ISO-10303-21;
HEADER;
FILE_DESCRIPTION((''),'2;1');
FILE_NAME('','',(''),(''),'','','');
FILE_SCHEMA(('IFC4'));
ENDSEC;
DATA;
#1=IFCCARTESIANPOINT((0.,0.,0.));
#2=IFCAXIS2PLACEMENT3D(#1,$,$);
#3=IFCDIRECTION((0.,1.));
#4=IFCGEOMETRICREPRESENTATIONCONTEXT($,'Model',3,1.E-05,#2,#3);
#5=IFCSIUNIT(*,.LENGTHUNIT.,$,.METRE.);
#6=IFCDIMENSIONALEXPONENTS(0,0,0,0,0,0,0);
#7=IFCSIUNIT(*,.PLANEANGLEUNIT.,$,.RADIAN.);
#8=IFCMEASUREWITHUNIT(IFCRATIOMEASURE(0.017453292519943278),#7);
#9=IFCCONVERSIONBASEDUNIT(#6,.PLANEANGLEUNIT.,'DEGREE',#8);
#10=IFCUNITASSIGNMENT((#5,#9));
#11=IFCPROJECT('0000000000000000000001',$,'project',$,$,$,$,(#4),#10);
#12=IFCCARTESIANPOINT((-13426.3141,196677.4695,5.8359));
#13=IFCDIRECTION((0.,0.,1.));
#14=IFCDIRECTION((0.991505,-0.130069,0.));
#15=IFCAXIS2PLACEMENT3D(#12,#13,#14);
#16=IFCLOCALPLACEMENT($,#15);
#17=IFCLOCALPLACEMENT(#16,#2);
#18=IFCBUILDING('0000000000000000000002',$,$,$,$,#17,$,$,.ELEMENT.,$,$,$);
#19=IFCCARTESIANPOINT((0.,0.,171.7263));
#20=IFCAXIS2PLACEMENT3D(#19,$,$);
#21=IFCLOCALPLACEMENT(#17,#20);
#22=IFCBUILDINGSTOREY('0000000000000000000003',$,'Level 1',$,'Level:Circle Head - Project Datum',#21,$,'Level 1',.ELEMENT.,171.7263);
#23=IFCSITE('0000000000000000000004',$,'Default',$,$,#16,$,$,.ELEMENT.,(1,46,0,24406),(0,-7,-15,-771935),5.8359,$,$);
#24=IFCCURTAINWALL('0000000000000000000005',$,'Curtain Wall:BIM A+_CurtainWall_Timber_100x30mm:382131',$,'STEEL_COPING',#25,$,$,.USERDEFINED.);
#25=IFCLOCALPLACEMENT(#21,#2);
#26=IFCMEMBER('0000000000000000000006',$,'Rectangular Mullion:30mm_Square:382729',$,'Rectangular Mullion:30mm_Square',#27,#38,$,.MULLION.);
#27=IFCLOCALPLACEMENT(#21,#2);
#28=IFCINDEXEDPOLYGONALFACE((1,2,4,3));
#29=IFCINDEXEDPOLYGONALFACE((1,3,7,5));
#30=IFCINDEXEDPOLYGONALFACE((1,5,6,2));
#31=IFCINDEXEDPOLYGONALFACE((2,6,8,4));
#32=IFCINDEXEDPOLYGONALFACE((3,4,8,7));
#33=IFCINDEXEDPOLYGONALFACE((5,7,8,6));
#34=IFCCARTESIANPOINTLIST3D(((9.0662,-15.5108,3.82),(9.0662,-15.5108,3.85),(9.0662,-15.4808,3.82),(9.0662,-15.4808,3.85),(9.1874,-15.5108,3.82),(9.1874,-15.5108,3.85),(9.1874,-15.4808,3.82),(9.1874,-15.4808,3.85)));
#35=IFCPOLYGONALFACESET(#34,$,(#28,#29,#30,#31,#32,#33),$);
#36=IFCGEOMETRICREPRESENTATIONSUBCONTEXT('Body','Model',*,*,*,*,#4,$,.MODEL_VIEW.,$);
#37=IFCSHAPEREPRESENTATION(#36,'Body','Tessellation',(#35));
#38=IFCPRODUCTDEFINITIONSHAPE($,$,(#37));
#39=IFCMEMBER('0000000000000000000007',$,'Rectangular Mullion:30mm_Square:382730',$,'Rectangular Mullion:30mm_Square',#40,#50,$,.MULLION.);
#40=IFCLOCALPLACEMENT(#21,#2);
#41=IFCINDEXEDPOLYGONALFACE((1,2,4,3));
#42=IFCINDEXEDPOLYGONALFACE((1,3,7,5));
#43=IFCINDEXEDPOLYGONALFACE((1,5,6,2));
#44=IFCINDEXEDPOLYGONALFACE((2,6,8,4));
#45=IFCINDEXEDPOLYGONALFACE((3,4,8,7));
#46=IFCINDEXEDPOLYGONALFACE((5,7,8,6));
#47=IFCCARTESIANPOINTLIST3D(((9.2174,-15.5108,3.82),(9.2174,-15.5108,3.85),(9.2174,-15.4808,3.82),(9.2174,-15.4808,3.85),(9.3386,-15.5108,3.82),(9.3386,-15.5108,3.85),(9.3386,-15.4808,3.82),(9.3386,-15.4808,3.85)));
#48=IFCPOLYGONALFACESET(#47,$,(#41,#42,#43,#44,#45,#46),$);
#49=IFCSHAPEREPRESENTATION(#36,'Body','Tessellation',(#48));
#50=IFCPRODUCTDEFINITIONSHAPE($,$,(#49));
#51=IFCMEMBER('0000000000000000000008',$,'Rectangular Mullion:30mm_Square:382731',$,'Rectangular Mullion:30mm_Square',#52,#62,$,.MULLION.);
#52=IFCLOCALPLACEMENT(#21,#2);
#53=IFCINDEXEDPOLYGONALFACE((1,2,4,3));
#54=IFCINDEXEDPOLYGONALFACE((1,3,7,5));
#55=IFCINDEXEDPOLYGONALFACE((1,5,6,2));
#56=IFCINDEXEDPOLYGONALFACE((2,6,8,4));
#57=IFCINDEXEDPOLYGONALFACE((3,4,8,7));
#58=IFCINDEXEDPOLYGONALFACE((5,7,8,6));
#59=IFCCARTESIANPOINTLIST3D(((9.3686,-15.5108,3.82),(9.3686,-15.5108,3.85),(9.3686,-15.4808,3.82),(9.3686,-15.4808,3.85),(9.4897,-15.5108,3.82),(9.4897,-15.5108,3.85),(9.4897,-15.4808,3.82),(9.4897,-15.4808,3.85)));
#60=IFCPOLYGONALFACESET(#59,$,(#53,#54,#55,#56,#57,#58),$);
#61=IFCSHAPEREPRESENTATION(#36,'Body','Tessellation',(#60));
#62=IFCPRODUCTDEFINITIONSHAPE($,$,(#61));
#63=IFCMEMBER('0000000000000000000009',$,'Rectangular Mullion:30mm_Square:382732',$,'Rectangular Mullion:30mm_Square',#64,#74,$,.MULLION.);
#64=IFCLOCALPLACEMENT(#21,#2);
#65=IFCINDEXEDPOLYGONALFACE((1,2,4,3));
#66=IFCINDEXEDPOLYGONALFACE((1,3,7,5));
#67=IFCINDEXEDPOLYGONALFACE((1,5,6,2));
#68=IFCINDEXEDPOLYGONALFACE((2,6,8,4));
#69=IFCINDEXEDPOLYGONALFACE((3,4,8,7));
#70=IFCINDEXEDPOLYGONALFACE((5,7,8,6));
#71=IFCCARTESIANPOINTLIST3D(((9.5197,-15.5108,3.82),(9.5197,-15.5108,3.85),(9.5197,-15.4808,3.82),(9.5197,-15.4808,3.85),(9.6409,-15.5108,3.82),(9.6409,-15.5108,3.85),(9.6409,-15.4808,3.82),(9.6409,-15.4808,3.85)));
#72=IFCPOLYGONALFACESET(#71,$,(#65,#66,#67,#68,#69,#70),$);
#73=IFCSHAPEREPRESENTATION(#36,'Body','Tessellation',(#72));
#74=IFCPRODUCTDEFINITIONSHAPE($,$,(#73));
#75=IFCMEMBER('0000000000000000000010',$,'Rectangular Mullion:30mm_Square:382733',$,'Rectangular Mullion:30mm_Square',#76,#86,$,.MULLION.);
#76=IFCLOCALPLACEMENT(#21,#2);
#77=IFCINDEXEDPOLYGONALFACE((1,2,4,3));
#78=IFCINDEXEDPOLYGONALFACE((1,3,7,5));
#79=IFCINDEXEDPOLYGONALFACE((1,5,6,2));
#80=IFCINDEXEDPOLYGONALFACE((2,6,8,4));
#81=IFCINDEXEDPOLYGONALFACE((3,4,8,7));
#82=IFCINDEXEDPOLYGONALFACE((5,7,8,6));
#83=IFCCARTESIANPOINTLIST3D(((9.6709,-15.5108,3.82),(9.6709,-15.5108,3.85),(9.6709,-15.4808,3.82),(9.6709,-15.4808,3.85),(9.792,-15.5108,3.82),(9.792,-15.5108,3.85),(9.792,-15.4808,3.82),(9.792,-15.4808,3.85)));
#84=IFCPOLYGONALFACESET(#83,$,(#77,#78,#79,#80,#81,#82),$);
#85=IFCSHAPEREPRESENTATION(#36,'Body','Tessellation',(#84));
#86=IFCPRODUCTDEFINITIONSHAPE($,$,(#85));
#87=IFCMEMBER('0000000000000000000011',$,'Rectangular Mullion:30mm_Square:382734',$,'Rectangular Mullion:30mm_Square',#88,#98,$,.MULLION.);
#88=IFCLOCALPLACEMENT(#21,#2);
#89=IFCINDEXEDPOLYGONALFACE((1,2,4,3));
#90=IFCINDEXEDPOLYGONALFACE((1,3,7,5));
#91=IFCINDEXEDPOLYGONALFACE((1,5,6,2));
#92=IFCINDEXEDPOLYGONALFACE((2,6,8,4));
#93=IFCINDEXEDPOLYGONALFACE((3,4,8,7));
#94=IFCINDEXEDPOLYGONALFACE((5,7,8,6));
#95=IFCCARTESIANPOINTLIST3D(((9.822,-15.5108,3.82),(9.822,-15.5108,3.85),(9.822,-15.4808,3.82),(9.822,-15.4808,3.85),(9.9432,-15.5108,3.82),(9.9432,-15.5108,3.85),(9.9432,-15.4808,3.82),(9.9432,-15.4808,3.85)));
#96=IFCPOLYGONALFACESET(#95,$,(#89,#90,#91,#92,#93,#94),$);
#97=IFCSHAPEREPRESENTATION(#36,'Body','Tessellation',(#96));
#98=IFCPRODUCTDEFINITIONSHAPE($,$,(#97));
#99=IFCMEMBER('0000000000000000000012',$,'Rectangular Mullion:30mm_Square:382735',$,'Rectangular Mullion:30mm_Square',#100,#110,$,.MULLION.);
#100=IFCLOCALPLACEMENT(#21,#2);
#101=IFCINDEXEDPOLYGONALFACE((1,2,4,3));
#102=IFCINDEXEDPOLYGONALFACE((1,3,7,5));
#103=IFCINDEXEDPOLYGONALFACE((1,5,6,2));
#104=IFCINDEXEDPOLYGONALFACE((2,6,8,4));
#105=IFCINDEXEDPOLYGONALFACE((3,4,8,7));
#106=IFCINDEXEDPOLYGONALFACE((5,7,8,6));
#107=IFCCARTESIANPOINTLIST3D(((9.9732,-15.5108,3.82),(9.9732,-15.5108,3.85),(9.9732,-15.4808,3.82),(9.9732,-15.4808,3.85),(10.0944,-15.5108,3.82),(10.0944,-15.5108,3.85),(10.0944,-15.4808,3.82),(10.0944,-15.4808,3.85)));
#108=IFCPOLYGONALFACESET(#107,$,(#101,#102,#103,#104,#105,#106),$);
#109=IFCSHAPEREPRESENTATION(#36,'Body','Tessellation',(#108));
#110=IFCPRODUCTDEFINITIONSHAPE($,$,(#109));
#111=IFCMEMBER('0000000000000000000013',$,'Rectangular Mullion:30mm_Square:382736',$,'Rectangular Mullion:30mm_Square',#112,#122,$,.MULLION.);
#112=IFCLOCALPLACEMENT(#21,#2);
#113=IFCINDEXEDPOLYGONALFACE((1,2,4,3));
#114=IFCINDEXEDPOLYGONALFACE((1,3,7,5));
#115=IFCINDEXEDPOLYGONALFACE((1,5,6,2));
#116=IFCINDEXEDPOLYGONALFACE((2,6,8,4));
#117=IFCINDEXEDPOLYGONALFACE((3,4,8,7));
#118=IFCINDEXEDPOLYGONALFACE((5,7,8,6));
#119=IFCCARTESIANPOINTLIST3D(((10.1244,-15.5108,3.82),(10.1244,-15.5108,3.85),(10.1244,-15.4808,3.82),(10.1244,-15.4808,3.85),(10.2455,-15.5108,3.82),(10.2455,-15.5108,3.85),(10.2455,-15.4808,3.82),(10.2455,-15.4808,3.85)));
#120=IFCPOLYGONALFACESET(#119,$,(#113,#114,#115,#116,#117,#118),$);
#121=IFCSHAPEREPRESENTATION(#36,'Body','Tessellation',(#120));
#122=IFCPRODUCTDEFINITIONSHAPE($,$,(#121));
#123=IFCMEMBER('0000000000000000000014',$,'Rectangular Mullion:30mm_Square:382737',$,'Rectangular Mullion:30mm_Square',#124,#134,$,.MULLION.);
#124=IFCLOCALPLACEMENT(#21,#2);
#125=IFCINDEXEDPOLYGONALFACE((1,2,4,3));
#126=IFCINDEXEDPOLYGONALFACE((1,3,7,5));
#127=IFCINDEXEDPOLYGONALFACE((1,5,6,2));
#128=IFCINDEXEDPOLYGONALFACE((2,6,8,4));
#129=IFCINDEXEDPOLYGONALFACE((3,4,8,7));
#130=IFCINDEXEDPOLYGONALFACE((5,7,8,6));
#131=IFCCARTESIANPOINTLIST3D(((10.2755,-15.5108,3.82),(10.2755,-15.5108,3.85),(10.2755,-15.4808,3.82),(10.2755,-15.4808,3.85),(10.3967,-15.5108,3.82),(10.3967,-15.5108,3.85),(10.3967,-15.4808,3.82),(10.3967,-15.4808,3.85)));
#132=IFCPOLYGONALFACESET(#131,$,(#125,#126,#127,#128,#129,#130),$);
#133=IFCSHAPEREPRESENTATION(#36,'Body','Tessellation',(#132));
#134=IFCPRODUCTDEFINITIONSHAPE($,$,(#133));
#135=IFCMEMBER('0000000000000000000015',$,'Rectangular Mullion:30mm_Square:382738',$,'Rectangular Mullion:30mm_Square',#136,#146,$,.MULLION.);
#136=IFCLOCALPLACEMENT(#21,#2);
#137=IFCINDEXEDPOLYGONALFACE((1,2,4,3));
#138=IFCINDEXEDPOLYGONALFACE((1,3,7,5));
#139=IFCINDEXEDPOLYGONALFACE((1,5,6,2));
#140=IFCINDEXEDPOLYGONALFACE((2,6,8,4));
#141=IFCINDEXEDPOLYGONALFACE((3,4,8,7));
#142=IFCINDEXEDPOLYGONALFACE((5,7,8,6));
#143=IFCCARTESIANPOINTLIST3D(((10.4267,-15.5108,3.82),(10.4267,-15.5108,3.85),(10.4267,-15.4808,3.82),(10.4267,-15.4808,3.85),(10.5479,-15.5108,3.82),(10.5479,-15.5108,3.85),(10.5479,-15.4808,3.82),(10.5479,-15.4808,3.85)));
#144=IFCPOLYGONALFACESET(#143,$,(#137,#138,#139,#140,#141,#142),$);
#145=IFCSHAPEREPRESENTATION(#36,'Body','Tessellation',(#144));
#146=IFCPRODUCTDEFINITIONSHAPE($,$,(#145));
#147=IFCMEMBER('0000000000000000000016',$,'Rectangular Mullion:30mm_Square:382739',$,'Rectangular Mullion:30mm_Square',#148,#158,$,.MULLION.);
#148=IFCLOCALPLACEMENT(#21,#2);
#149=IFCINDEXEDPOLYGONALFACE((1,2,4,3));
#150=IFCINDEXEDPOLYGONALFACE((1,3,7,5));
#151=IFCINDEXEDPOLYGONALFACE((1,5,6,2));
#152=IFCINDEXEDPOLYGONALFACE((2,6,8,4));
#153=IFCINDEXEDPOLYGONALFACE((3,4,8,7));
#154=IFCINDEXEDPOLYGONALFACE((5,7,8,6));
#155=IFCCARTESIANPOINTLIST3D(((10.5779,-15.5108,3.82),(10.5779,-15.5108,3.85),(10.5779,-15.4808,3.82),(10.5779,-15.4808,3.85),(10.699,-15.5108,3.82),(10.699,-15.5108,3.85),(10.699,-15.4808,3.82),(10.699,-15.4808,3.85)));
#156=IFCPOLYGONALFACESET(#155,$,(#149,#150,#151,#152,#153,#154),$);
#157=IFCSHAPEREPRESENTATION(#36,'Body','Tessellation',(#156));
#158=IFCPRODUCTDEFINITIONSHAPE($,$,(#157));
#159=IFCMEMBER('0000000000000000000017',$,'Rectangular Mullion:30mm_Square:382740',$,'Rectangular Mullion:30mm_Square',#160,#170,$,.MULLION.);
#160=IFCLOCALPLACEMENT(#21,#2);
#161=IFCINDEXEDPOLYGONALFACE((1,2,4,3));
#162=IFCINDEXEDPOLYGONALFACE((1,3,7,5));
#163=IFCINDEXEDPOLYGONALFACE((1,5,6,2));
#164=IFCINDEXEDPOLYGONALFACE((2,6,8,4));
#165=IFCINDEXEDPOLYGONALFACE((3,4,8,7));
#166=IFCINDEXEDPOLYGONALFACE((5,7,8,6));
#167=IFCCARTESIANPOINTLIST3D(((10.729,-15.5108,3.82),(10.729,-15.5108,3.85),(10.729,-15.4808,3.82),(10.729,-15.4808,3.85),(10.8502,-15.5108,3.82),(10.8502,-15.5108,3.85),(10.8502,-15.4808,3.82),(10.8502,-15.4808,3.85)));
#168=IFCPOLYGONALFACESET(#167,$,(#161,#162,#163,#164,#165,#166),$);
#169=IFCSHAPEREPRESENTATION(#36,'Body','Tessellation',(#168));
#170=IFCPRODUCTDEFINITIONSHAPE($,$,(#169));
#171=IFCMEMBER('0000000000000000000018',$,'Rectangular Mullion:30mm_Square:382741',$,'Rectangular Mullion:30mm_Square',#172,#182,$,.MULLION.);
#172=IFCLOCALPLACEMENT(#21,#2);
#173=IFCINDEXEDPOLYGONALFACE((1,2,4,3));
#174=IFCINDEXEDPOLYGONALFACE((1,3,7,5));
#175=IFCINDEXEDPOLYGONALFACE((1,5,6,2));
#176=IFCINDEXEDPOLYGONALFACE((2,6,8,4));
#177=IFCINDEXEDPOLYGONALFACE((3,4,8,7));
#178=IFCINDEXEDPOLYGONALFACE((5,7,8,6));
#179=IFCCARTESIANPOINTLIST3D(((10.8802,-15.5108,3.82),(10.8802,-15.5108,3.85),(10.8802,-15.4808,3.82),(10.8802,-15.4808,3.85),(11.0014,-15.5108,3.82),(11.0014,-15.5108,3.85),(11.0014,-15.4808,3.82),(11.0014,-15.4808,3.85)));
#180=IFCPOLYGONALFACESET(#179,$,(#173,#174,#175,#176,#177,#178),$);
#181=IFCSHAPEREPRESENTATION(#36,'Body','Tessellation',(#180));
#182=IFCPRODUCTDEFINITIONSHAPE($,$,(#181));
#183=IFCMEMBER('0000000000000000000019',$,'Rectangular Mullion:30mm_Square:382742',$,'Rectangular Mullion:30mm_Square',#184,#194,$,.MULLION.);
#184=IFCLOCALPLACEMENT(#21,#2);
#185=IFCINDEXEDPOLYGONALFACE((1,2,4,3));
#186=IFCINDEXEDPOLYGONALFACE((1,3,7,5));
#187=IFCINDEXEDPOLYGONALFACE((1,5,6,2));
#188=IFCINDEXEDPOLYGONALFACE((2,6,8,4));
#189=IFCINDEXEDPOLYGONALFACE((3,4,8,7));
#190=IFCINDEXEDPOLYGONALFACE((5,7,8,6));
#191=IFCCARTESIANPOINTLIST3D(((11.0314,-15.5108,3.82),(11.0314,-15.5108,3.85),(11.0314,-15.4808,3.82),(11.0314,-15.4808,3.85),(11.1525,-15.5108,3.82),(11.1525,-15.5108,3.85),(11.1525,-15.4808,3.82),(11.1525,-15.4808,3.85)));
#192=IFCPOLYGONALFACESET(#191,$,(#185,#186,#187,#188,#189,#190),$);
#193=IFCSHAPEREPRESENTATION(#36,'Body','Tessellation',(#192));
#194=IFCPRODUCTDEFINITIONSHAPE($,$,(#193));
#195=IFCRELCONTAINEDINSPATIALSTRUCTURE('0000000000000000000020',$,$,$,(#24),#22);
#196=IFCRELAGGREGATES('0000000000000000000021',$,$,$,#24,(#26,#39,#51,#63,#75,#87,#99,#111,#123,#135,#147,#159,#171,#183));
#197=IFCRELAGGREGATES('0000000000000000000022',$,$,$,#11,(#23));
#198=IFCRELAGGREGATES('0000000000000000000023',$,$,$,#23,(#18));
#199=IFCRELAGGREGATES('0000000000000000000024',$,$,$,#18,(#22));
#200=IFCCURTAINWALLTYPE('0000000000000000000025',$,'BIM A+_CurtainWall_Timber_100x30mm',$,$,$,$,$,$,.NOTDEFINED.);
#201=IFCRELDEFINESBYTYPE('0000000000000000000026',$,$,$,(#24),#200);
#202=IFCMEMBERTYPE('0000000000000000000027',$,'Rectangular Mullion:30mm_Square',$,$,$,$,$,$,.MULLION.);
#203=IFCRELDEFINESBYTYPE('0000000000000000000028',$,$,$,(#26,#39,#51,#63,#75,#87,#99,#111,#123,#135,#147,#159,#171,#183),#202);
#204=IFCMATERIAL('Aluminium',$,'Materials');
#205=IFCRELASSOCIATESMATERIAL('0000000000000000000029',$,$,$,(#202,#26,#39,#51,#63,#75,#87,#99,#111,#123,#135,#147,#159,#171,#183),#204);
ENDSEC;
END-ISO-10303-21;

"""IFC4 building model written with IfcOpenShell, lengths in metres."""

from ifc_helpers import new_model, entity, si_unit, converted_unit, direction, frame, origin, place, context, subcontext, project, spatial, indexed_curve, outline, extrude, source, transform, mapped, material, type_object, type_shapes, element, aggregate, save


model = new_model("IFC4")

# Units and contexts
model_context = context("Model", 3, precision=1e-05, world=origin(), true_north=direction((0.0, 1.0)))
body_context = subcontext(model_context, "Body", "Model", "MODEL_VIEW")
ifc_project = project(units=[si_unit("LENGTHUNIT", "METRE"), converted_unit("PLANEANGLEUNIT", "DEGREE", entity("IfcRatioMeasure", 0.017453292519943278), si_unit("PLANEANGLEUNIT", "RADIAN"), dimensions=[0, 0, 0, 0, 0, 0, 0])], contexts=[model_context])

# Site, building, storey
site_placement = place(None, frame((-13426.3141, 196677.4695, 5.8359), z_axis=(0.0, 0.0, 1.0), x_axis=(0.991505, -0.130069, 0.0)))
site = spatial("IfcSite", under=ifc_project, at=site_placement, Name="Default", CompositionType="ELEMENT", RefLatitude=(1, 46, 0, 24406), RefLongitude=(0, -7, -15, -771935), RefElevation=5.8359)
building_placement = place(site_placement, origin())
building = spatial("IfcBuilding", under=site, at=building_placement, CompositionType="ELEMENT")
storey_placement = place(building_placement, frame((0.0, 0.0, 171.7263)))
storey = spatial("IfcBuildingStorey", under=building, at=storey_placement, Name="Level 1", ObjectType="Level:Circle Head - Project Datum", LongName="Level 1", CompositionType="ELEMENT", Elevation=171.7263)

# Curtain wall, members
curtain_wall_type = type_object("IfcCurtainWallType", Name="BIM A+_CurtainWall_Timber_100x30mm", PredefinedType="NOTDEFINED")
curtain_wall_placement = place(storey_placement, frame((0.0, 0.0, -171.7263)))
curtain_wall = element("IfcCurtainWall", 1, at=curtain_wall_placement, inside=storey, type_object=curtain_wall_type, Name="Curtain Wall:BIM A+_CurtainWall_Timber_100x30mm:382131", ObjectType="STEEL_COPING", PredefinedType="USERDEFINED")
ifc_material_1 = material(Name="Aluminium", Category="Materials")
member_type_1 = type_object("IfcMemberType", Name="Rectangular Mullion:30mm_Square", PredefinedType="MULLION", material=ifc_material_1)
shared_shape_1 = source(origin(), body_context, "Body", "SweptSolid", [
    extrude(outline(indexed_curve([(-0.015, -0.015), (0.015, -0.015), (0.015, 0.015), (-0.015, 0.015), (-0.015, -0.015)], self_intersect=False)), frame((-0.015, 0.0, -0.1212), z_axis=(0.0, 0.0, 1.0), x_axis=(0.0, -1.0, 0.0)), (0.0, 0.0, 1.0), 0.1212),
])
type_shapes(member_type_1, [shared_shape_1])
member_1_placement = place(curtain_wall_placement, frame((9.1874, -15.4958, 175.5763), z_axis=(1.0, 0.0, 0.0), x_axis=(0.0, 0.0, 1.0)))
member_1 = element("IfcMember", 2, at=member_1_placement, type_object=member_type_1, material=ifc_material_1, Name="Rectangular Mullion:30mm_Square:382729", ObjectType="Rectangular Mullion:30mm_Square", PredefinedType="MULLION", context=body_context, shape_type="MappedRepresentation", body=[
    mapped(shared_shape_1, transform((0.0, 0.0, 0.0), scale=1.0)),
])
member_2_placement = place(curtain_wall_placement, frame((9.3386, -15.4958, 175.5763), z_axis=(1.0, 0.0, 0.0), x_axis=(0.0, 0.0, 1.0)))
member_2 = element("IfcMember", 3, at=member_2_placement, type_object=member_type_1, material=ifc_material_1, Name="Rectangular Mullion:30mm_Square:382730", ObjectType="Rectangular Mullion:30mm_Square", PredefinedType="MULLION", context=body_context, shape_type="MappedRepresentation", body=[
    mapped(shared_shape_1, transform((0.0, 0.0, 0.0), scale=1.0)),
])
member_3_placement = place(curtain_wall_placement, frame((9.4897, -15.4958, 175.5763), z_axis=(1.0, 0.0, 0.0), x_axis=(0.0, 0.0, 1.0)))
member_3 = element("IfcMember", 4, at=member_3_placement, type_object=member_type_1, material=ifc_material_1, Name="Rectangular Mullion:30mm_Square:382731", ObjectType="Rectangular Mullion:30mm_Square", PredefinedType="MULLION", context=body_context, shape_type="MappedRepresentation", body=[
    mapped(shared_shape_1, transform((0.0, 0.0, 0.0), scale=1.0)),
])
member_4_placement = place(curtain_wall_placement, frame((9.6409, -15.4958, 175.5763), z_axis=(1.0, 0.0, 0.0), x_axis=(0.0, 0.0, 1.0)))
member_4 = element("IfcMember", 5, at=member_4_placement, type_object=member_type_1, material=ifc_material_1, Name="Rectangular Mullion:30mm_Square:382732", ObjectType="Rectangular Mullion:30mm_Square", PredefinedType="MULLION", context=body_context, shape_type="MappedRepresentation", body=[
    mapped(shared_shape_1, transform((0.0, 0.0, 0.0), scale=1.0)),
])
member_5_placement = place(curtain_wall_placement, frame((9.792, -15.4958, 175.5763), z_axis=(1.0, 0.0, 0.0), x_axis=(0.0, 0.0, 1.0)))
member_5 = element("IfcMember", 6, at=member_5_placement, type_object=member_type_1, material=ifc_material_1, Name="Rectangular Mullion:30mm_Square:382733", ObjectType="Rectangular Mullion:30mm_Square", PredefinedType="MULLION", context=body_context, shape_type="MappedRepresentation", body=[
    mapped(shared_shape_1, transform((0.0, 0.0, 0.0), scale=1.0)),
])
member_6_placement = place(curtain_wall_placement, frame((9.9432, -15.4958, 175.5763), z_axis=(1.0, 0.0, 0.0), x_axis=(0.0, 0.0, 1.0)))
member_6 = element("IfcMember", 7, at=member_6_placement, type_object=member_type_1, material=ifc_material_1, Name="Rectangular Mullion:30mm_Square:382734", ObjectType="Rectangular Mullion:30mm_Square", PredefinedType="MULLION", context=body_context, shape_type="MappedRepresentation", body=[
    mapped(shared_shape_1, transform((0.0, 0.0, 0.0), scale=1.0)),
])
member_7_placement = place(curtain_wall_placement, frame((10.0944, -15.4958, 175.5763), z_axis=(1.0, 0.0, 0.0), x_axis=(0.0, 0.0, 1.0)))
member_7 = element("IfcMember", 8, at=member_7_placement, type_object=member_type_1, material=ifc_material_1, Name="Rectangular Mullion:30mm_Square:382735", ObjectType="Rectangular Mullion:30mm_Square", PredefinedType="MULLION", context=body_context, shape_type="MappedRepresentation", body=[
    mapped(shared_shape_1, transform((0.0, 0.0, 0.0), scale=1.0)),
])
member_8_placement = place(curtain_wall_placement, frame((10.2455, -15.4958, 175.5763), z_axis=(1.0, 0.0, 0.0), x_axis=(0.0, 0.0, 1.0)))
member_8 = element("IfcMember", 9, at=member_8_placement, type_object=member_type_1, material=ifc_material_1, Name="Rectangular Mullion:30mm_Square:382736", ObjectType="Rectangular Mullion:30mm_Square", PredefinedType="MULLION", context=body_context, shape_type="MappedRepresentation", body=[
    mapped(shared_shape_1, transform((0.0, 0.0, 0.0), scale=1.0)),
])
member_9_placement = place(curtain_wall_placement, frame((10.3967, -15.4958, 175.5763), z_axis=(1.0, 0.0, 0.0), x_axis=(0.0, 0.0, 1.0)))
member_9 = element("IfcMember", 10, at=member_9_placement, type_object=member_type_1, material=ifc_material_1, Name="Rectangular Mullion:30mm_Square:382737", ObjectType="Rectangular Mullion:30mm_Square", PredefinedType="MULLION", context=body_context, shape_type="MappedRepresentation", body=[
    mapped(shared_shape_1, transform((0.0, 0.0, 0.0), scale=1.0)),
])
member_10_placement = place(curtain_wall_placement, frame((10.5479, -15.4958, 175.5763), z_axis=(1.0, 0.0, 0.0), x_axis=(0.0, 0.0, 1.0)))
member_10 = element("IfcMember", 11, at=member_10_placement, type_object=member_type_1, material=ifc_material_1, Name="Rectangular Mullion:30mm_Square:382738", ObjectType="Rectangular Mullion:30mm_Square", PredefinedType="MULLION", context=body_context, shape_type="MappedRepresentation", body=[
    mapped(shared_shape_1, transform((0.0, 0.0, 0.0), scale=1.0)),
])
member_11_placement = place(curtain_wall_placement, frame((10.699, -15.4958, 175.5763), z_axis=(1.0, 0.0, 0.0), x_axis=(0.0, 0.0, 1.0)))
member_11 = element("IfcMember", 12, at=member_11_placement, type_object=member_type_1, material=ifc_material_1, Name="Rectangular Mullion:30mm_Square:382739", ObjectType="Rectangular Mullion:30mm_Square", PredefinedType="MULLION", context=body_context, shape_type="MappedRepresentation", body=[
    mapped(shared_shape_1, transform((0.0, 0.0, 0.0), scale=1.0)),
])
member_12_placement = place(curtain_wall_placement, frame((10.8502, -15.4958, 175.5763), z_axis=(1.0, 0.0, 0.0), x_axis=(0.0, 0.0, 1.0)))
member_12 = element("IfcMember", 13, at=member_12_placement, type_object=member_type_1, material=ifc_material_1, Name="Rectangular Mullion:30mm_Square:382740", ObjectType="Rectangular Mullion:30mm_Square", PredefinedType="MULLION", context=body_context, shape_type="MappedRepresentation", body=[
    mapped(shared_shape_1, transform((0.0, 0.0, 0.0), scale=1.0)),
])
member_13_placement = place(curtain_wall_placement, frame((11.0014, -15.4958, 175.5763), z_axis=(1.0, 0.0, 0.0), x_axis=(0.0, 0.0, 1.0)))
member_13 = element("IfcMember", 14, at=member_13_placement, type_object=member_type_1, material=ifc_material_1, Name="Rectangular Mullion:30mm_Square:382741", ObjectType="Rectangular Mullion:30mm_Square", PredefinedType="MULLION", context=body_context, shape_type="MappedRepresentation", body=[
    mapped(shared_shape_1, transform((0.0, 0.0, 0.0), scale=1.0)),
])
member_14_placement = place(curtain_wall_placement, frame((11.1525, -15.4958, 175.5763), z_axis=(1.0, 0.0, 0.0), x_axis=(0.0, 0.0, 1.0)))
member_14 = element("IfcMember", 15, at=member_14_placement, type_object=member_type_1, material=ifc_material_1, Name="Rectangular Mullion:30mm_Square:382742", ObjectType="Rectangular Mullion:30mm_Square", PredefinedType="MULLION", context=body_context, shape_type="MappedRepresentation", body=[
    mapped(shared_shape_1, transform((0.0, 0.0, 0.0), scale=1.0)),
])
aggregate(curtain_wall, [member_1, member_2, member_3, member_4, member_5, member_6, member_7, member_8, member_9, member_10, member_11, member_12, member_13, member_14])

save(model, "model.ifc")
